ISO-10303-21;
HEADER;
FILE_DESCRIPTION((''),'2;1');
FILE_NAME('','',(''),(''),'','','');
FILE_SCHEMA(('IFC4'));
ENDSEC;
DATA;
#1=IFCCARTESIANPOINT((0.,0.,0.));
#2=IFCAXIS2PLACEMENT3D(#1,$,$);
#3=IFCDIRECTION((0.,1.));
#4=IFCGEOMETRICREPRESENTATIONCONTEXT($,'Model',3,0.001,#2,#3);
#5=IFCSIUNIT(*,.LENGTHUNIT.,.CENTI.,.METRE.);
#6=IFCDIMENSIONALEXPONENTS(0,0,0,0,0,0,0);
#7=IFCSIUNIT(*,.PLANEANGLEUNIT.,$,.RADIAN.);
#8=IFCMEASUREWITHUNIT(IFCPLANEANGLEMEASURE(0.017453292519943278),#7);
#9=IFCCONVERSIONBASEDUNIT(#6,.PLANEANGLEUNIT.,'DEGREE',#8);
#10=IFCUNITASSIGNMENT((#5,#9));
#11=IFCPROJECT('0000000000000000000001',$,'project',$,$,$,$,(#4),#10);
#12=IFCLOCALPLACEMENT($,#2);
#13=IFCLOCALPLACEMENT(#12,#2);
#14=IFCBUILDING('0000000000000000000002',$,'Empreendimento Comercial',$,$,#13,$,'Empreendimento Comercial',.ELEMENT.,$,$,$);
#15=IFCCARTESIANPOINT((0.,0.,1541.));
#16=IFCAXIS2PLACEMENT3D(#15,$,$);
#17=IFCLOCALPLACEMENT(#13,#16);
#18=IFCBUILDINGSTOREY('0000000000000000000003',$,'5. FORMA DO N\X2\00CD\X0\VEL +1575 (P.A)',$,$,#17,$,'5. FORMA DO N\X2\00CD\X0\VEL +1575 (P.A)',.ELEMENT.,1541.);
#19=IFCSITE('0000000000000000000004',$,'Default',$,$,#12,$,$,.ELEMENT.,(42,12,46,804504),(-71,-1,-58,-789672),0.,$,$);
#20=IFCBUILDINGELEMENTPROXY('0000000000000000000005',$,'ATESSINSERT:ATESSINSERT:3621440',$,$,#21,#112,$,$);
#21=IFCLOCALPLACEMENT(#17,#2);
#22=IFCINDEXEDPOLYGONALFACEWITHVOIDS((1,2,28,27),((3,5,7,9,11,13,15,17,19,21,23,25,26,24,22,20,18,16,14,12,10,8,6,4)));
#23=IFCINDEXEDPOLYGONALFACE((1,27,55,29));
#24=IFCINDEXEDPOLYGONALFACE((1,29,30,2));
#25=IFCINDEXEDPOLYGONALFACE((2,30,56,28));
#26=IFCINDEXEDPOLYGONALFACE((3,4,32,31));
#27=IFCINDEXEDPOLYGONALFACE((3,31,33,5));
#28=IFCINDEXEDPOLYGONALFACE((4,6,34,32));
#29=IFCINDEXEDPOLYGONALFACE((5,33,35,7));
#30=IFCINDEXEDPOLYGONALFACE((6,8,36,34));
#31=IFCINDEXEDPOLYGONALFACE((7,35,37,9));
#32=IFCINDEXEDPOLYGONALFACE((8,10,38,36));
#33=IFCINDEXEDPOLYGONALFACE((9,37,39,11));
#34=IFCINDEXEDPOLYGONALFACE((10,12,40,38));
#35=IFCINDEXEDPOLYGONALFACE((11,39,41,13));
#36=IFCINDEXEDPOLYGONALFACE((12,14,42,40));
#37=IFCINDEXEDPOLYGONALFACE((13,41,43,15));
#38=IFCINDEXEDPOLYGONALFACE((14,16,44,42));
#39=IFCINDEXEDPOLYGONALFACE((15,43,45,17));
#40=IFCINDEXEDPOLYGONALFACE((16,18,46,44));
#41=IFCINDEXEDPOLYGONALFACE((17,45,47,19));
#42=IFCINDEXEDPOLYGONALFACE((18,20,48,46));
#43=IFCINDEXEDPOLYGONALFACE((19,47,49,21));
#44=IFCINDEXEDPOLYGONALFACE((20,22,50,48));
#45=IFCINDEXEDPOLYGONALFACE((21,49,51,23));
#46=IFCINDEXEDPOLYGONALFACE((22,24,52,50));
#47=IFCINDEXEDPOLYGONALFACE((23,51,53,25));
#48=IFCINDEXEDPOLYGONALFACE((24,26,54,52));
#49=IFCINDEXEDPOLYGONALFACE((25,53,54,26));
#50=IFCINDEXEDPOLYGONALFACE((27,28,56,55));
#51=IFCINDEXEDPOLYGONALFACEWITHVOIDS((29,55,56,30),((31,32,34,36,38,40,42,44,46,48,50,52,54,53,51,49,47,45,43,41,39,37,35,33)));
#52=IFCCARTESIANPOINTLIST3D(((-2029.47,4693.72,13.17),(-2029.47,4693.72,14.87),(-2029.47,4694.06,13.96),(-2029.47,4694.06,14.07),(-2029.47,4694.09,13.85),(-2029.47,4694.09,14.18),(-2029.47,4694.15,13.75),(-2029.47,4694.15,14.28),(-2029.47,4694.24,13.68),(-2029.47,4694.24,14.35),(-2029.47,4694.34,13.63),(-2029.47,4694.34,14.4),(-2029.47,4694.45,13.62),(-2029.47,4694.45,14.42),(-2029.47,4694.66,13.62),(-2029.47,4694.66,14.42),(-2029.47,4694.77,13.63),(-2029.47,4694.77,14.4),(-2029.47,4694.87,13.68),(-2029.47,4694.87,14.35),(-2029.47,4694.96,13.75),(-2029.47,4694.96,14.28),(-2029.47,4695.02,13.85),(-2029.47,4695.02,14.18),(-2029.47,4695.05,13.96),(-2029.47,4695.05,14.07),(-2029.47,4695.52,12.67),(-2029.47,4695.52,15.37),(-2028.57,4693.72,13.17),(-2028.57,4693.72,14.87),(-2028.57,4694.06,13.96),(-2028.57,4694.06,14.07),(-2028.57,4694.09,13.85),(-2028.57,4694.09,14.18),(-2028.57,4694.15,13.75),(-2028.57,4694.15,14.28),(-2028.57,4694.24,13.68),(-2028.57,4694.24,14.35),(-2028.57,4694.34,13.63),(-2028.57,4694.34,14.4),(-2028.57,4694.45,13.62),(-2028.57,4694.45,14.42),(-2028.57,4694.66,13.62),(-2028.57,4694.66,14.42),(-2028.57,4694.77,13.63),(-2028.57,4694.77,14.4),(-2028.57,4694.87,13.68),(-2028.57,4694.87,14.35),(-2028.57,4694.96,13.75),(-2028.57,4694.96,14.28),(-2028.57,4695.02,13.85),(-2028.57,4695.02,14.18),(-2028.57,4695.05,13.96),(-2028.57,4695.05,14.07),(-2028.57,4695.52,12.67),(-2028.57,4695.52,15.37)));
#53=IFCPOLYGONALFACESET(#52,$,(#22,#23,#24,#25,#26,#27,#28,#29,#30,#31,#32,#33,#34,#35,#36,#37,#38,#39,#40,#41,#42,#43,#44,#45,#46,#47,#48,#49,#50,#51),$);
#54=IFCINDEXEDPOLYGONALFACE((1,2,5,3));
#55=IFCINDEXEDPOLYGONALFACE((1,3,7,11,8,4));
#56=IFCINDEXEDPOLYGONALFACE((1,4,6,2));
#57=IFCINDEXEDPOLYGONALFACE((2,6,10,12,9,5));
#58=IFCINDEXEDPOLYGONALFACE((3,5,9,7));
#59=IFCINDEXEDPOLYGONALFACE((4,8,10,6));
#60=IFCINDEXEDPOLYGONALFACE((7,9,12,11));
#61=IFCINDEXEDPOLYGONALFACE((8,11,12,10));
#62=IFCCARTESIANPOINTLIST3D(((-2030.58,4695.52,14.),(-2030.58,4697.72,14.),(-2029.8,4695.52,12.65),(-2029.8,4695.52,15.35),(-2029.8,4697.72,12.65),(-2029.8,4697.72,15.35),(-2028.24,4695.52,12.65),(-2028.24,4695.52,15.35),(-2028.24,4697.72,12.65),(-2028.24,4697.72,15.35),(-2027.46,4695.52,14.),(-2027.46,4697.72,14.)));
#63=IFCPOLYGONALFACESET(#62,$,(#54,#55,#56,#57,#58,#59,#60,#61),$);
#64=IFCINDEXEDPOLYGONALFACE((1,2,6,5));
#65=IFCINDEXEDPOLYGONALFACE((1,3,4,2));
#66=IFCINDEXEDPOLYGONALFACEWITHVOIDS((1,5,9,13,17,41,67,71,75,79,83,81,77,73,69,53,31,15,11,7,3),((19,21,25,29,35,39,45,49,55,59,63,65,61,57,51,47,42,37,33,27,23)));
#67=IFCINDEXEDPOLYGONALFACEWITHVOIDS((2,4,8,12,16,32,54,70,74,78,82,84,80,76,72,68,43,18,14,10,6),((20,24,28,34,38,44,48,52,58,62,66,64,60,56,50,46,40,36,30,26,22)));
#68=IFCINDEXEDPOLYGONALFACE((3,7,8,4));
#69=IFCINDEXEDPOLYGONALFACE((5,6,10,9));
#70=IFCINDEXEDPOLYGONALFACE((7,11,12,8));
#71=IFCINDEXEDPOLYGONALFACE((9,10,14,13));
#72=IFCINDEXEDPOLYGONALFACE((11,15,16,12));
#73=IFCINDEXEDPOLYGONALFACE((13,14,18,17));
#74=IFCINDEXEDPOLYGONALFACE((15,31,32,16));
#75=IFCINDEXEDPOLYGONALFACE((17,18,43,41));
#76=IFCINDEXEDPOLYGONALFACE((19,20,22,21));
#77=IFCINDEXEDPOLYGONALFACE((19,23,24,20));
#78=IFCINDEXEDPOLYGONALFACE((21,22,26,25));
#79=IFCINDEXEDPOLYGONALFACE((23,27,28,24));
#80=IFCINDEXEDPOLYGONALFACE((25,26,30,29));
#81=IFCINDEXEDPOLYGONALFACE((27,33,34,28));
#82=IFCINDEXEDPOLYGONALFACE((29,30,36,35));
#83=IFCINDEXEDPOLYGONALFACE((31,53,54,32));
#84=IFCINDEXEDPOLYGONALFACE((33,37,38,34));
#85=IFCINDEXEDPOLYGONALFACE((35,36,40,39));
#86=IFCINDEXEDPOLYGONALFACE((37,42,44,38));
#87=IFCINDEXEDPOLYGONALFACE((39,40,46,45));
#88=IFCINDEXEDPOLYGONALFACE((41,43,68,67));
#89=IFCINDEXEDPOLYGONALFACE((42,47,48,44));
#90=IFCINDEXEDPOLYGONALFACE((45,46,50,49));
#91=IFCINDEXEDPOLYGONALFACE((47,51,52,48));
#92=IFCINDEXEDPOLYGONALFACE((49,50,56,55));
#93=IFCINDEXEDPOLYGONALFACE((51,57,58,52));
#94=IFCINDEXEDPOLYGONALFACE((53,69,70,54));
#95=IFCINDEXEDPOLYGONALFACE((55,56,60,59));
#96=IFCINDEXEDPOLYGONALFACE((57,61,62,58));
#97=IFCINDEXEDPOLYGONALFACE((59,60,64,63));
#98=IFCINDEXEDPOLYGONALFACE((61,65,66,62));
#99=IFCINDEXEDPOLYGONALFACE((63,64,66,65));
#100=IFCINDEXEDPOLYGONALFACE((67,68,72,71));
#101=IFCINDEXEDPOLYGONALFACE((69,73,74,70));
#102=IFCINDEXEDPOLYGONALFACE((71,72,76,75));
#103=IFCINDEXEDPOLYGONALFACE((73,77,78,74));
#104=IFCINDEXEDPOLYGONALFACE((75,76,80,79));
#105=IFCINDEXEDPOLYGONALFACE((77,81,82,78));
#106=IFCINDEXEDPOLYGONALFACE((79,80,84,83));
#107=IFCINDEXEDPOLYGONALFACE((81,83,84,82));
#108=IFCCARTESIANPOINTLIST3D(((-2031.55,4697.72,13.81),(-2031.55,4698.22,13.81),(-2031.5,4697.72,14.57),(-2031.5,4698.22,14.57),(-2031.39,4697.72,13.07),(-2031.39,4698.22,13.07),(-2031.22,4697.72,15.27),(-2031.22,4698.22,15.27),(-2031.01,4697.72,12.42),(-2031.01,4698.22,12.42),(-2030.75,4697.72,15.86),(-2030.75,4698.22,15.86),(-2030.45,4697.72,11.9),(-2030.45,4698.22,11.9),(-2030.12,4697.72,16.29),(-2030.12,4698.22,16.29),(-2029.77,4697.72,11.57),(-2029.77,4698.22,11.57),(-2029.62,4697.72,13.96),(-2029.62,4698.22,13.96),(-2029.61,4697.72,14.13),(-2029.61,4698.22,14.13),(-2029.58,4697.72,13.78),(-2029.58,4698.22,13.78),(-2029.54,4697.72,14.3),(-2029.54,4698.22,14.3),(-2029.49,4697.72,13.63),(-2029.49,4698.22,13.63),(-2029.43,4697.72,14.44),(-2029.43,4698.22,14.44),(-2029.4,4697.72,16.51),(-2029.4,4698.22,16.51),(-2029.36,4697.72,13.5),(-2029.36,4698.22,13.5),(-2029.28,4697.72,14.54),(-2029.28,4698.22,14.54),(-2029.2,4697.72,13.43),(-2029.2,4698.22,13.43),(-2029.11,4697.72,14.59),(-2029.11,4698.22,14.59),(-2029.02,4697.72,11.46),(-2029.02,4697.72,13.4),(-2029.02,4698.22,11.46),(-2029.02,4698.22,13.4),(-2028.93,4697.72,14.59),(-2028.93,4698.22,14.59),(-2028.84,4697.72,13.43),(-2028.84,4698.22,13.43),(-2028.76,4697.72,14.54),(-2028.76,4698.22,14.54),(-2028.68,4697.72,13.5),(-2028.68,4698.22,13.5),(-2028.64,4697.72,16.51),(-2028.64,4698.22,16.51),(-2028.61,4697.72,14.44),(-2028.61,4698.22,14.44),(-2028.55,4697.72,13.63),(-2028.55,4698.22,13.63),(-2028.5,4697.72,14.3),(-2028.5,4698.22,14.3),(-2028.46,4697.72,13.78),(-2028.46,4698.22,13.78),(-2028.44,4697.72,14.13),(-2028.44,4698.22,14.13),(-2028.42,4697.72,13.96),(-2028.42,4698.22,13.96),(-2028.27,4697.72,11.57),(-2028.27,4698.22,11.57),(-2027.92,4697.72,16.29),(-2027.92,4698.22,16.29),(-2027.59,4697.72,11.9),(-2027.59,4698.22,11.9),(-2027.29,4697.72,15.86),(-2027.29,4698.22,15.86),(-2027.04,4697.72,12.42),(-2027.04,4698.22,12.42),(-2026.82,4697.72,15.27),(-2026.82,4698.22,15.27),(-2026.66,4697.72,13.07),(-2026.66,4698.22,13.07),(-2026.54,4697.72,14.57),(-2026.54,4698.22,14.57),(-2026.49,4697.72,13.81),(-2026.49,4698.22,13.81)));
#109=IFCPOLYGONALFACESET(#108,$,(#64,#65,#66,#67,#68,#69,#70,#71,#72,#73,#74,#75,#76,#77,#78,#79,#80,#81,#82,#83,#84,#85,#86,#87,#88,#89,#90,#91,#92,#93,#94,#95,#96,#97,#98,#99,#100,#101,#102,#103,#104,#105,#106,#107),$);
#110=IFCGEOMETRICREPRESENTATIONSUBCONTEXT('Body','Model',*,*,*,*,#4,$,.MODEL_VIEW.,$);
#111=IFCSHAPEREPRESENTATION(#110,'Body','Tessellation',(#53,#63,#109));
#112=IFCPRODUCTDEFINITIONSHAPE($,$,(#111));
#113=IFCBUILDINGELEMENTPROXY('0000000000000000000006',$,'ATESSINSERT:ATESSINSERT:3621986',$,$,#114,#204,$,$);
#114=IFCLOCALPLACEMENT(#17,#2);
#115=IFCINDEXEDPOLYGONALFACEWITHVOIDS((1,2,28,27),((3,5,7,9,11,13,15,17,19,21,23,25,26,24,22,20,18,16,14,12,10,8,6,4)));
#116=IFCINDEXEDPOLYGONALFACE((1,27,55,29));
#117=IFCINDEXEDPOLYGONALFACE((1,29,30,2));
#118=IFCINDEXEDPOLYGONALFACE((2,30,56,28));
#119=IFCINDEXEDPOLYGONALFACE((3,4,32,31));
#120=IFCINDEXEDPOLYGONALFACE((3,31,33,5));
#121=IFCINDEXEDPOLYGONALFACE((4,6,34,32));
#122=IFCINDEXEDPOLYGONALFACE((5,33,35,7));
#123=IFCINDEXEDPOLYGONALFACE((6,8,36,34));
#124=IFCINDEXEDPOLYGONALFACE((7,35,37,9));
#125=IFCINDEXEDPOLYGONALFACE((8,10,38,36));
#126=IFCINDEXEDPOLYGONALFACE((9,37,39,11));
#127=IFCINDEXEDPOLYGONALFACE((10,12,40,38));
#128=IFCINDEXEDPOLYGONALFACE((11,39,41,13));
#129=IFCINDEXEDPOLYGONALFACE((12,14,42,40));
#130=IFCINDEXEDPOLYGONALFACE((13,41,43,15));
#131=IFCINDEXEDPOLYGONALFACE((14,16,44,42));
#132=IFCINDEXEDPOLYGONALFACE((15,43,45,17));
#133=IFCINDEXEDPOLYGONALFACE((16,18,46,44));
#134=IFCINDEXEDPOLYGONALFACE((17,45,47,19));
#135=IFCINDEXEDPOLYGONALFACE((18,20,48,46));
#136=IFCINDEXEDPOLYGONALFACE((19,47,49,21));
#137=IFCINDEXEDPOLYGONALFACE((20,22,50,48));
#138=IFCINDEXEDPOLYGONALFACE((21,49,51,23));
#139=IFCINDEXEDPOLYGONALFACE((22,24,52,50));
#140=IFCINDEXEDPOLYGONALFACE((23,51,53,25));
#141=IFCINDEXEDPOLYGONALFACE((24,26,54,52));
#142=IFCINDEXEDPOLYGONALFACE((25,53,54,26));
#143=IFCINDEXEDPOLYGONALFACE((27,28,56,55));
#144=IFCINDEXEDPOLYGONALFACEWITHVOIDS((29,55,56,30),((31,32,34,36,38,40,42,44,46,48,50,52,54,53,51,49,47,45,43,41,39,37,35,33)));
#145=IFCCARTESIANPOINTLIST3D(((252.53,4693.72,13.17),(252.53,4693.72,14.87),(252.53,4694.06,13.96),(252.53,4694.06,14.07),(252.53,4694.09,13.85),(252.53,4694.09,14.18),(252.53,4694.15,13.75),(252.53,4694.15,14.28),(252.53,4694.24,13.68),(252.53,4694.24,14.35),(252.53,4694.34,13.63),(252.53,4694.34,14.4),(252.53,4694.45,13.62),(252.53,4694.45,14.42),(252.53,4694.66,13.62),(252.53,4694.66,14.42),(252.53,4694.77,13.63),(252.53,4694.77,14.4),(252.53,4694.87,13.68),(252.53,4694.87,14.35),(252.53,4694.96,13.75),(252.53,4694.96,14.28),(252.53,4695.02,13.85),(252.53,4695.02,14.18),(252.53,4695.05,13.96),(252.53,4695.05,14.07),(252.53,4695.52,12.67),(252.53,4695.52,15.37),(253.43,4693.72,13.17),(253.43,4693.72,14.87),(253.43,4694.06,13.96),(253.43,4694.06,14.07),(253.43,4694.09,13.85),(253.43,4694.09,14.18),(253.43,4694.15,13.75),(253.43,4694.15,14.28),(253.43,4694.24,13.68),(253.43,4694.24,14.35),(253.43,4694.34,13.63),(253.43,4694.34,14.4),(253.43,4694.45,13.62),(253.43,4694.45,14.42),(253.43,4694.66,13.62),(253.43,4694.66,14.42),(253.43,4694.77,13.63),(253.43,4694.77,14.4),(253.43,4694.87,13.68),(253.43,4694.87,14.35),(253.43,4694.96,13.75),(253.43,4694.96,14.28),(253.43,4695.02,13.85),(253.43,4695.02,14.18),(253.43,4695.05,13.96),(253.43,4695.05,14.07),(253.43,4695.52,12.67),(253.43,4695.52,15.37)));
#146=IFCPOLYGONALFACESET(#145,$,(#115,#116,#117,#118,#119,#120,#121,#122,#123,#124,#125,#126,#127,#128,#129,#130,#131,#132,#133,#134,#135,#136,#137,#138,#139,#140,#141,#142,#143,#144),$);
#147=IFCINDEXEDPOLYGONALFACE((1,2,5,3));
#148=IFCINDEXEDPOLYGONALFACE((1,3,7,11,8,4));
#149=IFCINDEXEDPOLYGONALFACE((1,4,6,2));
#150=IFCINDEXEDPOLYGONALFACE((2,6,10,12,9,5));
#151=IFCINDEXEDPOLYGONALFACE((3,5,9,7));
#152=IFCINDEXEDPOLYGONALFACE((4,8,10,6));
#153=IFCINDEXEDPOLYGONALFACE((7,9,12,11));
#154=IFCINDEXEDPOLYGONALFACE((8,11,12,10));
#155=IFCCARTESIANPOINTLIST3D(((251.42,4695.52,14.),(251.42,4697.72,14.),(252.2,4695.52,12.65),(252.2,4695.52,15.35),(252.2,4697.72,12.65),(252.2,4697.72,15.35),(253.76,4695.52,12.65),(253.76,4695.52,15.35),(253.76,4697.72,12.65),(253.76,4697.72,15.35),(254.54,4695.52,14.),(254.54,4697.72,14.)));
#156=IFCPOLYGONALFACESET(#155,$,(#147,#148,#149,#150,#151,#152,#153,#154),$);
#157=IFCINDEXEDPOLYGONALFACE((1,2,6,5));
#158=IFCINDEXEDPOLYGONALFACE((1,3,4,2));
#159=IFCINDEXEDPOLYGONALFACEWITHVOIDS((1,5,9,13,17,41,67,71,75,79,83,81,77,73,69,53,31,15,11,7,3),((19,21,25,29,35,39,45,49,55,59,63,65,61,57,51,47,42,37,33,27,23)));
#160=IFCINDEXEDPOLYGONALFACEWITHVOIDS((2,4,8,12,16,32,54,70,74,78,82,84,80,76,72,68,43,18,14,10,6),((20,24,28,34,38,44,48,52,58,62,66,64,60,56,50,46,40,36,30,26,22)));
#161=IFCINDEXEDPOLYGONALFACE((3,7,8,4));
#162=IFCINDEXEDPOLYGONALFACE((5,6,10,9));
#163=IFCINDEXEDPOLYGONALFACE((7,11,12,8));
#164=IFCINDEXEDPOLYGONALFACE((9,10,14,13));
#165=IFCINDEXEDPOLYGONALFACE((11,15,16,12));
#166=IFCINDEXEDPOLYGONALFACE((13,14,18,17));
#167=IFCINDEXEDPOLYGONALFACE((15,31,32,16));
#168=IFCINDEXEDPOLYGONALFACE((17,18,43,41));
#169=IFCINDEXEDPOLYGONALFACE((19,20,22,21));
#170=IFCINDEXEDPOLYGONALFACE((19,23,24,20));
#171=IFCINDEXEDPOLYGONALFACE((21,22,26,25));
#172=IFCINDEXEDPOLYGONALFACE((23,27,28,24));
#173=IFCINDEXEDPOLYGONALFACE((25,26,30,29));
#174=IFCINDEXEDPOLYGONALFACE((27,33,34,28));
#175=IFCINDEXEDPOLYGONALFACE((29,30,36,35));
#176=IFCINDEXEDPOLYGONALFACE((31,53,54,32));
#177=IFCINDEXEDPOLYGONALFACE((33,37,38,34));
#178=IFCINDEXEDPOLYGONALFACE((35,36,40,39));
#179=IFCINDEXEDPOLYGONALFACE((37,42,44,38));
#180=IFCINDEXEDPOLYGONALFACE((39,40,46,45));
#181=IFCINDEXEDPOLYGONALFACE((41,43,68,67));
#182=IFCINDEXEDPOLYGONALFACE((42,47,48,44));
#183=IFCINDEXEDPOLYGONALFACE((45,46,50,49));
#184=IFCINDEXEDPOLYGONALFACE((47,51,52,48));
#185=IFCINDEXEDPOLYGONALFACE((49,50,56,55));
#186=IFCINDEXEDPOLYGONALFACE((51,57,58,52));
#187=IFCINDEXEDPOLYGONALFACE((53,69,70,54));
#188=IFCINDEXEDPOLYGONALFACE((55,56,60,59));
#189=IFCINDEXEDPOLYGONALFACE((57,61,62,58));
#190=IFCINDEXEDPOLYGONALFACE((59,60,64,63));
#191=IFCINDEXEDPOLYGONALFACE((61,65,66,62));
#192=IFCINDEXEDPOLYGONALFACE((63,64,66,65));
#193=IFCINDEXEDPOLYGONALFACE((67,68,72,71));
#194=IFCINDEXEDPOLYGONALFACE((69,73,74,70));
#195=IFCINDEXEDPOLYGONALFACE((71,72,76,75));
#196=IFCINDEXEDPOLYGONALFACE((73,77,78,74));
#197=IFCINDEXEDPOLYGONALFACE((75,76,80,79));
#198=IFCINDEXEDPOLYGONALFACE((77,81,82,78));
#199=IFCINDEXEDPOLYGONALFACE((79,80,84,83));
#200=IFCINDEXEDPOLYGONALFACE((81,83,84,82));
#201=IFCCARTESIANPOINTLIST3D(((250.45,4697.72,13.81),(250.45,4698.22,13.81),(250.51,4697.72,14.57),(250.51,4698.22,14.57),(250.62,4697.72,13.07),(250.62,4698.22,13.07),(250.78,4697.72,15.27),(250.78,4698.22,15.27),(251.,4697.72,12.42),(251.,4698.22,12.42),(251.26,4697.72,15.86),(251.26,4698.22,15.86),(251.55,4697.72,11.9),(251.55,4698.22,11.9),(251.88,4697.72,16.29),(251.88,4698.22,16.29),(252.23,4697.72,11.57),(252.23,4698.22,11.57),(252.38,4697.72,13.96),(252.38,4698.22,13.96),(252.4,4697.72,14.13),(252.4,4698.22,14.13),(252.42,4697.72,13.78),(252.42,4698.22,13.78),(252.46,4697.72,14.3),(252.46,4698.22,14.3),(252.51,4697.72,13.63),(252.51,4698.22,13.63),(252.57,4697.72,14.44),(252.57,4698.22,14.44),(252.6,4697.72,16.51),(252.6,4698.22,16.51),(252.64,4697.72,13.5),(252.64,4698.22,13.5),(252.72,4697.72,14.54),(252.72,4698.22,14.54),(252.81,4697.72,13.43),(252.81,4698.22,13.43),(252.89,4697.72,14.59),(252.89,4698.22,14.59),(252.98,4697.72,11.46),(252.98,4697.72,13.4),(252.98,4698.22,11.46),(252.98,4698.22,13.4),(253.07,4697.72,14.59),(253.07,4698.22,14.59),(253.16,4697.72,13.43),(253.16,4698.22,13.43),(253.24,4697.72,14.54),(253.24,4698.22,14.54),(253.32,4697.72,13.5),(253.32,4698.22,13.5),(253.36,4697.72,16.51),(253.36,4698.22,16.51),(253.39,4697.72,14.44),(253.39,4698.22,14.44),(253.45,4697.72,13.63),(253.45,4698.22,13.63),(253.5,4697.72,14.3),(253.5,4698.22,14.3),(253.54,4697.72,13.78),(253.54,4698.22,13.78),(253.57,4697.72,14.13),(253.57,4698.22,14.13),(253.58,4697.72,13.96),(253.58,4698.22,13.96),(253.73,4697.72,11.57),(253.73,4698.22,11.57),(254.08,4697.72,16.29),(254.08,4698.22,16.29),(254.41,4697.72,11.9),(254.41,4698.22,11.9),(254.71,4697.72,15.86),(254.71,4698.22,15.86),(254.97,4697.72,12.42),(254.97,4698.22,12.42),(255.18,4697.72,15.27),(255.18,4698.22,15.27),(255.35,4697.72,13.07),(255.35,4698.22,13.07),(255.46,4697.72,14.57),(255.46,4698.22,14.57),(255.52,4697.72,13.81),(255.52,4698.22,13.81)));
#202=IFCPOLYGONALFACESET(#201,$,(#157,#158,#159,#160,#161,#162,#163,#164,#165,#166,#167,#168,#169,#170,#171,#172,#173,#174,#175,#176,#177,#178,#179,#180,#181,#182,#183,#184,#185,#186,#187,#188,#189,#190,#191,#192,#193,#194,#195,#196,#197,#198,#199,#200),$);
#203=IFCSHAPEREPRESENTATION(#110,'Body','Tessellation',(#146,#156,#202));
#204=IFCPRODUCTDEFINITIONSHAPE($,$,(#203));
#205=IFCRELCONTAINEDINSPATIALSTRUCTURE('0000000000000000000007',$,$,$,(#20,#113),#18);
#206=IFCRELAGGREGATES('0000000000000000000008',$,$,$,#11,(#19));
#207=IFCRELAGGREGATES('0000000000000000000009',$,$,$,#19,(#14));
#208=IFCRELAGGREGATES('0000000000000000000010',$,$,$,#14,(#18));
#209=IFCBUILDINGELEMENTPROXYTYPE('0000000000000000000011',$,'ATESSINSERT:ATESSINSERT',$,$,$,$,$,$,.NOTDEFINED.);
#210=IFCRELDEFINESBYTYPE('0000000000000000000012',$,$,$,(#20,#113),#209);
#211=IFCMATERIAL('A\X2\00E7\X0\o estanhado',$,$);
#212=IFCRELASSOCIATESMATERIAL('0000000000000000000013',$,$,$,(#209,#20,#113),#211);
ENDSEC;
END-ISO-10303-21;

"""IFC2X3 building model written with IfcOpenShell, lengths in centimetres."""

from ifc_helpers import new_model, entity, si_unit, converted_unit, direction, frame, frame_2d, origin, place, context, subcontext, project, spatial, polyline, circle_curve, parameter, trimmed, segment, composite_curve, hollow_circle, outline, extrude, source, transform, mapped, material, type_object, type_shapes, element, save


model = new_model("IFC2X3")

# Units and contexts
model_context = context("Model", 3, precision=0.001, world=origin(), true_north=direction((0.0, 1.0)))
body_context = subcontext(model_context, "Body", "Model", "MODEL_VIEW")
ifc_project = project(units=[si_unit("LENGTHUNIT", "METRE", prefix="CENTI"), converted_unit("PLANEANGLEUNIT", "DEGREE", entity("IfcPlaneAngleMeasure", 0.017453292519943278), si_unit("PLANEANGLEUNIT", "RADIAN"), dimensions=[0, 0, 0, 0, 0, 0, 0])], contexts=[model_context])

# Site, building, storey
site_placement = place(None, origin())
site = spatial("IfcSite", under=ifc_project, at=site_placement, Name="Default", CompositionType="ELEMENT", RefLatitude=(42, 12, 46, 804504), RefLongitude=(-71, -1, -58, -789672), RefElevation=0.0)
building_placement = place(site_placement, origin())
building = spatial("IfcBuilding", under=site, at=building_placement, Name="Empreendimento Comercial", LongName="Empreendimento Comercial", CompositionType="ELEMENT")
storey_placement = place(building_placement, frame((0.0, 0.0, 1541.0)))
storey = spatial("IfcBuildingStorey", under=building, at=storey_placement, Name="5. FORMA DO NÍVEL +1575 (P.A)", LongName="5. FORMA DO NÍVEL +1575 (P.A)", CompositionType="ELEMENT", Elevation=1541.0)

# Building element proxies
ifc_material_1 = material(Name="Aço estanhado")
building_element_proxy_type_1 = type_object("IfcBuildingElementProxyType", Name="ATESSINSERT:ATESSINSERT", PredefinedType="NOTDEFINED", material=ifc_material_1)
shared_shape_1 = source(origin(), body_context, "Body", "SweptSolid", [
    extrude(outline(polyline([(-1.35, -0.9), (1.35, -0.9), (0.85, 0.9), (-0.85, 0.9), (-1.35, -0.9)]), holes=[composite_curve([segment(trimmed(circle_curve(frame_2d((0.0, 0.17), x_axis=(1.0, 0.0)), 0.4), [parameter(0.0)], [parameter(180.0)], True, "PARAMETER"), False, "CONTINUOUS"), segment(polyline([(0.4, 0.17), (0.4, -0.03)]), True, "CONTINUOUS"), segment(trimmed(circle_curve(frame_2d((0.0, -0.03), x_axis=(1.0, 0.0)), 0.4), [parameter(180.0)], [parameter(0.0)], True, "PARAMETER"), False, "CONTINUOUS"), segment(polyline([(-0.4, -0.03), (-0.4, 0.17)]), True, "CONTINUOUS")], self_intersect=False)]), frame((-1.4, -0.45, 30.02), z_axis=(0.0, 1.0, 0.0), x_axis=(0.0, 0.0, 1.0)), (0.0, 0.0, 1.0), 0.9),
    extrude(outline(polyline([(-0.78, -1.35), (0.78, -1.35), (1.56, 0.0), (0.78, 1.35), (-0.78, 1.35), (-1.56, 0.0), (-0.78, -1.35)])), frame((-4.5, 0.0, 30.0), z_axis=(1.0, 0.0, 0.0), x_axis=(0.0, 1.0, 0.0)), (0.0, 0.0, 1.0), 2.2),
    extrude(hollow_circle(Radius=2.54, WallThickness=1.94, at=frame_2d((0.0, 0.0), x_axis=(1.0, 0.0))), frame((-5.0, 0.0, 30.0), z_axis=(1.0, 0.0, 0.0), x_axis=(0.0, 0.0, -1.0)), (0.0, 0.0, 1.0), 0.5),
])
type_shapes(building_element_proxy_type_1, [shared_shape_1])
for number, where, z_axis, x_axis, name in (
    (1, (-2029.02, 4693.22, -16.0), (0.0, 0.0, 1.0), (0.0, -1.0, 0.0), "ATESSINSERT:ATESSINSERT:3621440"),
    (2, (252.98, 4693.22, -16.0), (0.0, 0.0, 1.0), (0.0, -1.0, 0.0), "ATESSINSERT:ATESSINSERT:3621986"),
):
    element("IfcBuildingElementProxy", number, at=place(storey_placement, frame(where, z_axis=z_axis, x_axis=x_axis)), inside=storey, type_object=building_element_proxy_type_1, material=ifc_material_1, Name=name, context=body_context, shape_type="MappedRepresentation", body=[
        mapped(shared_shape_1, transform((0.0, 0.0, 0.0), scale=1.0)),
    ])

save(model, "model.ifc")
